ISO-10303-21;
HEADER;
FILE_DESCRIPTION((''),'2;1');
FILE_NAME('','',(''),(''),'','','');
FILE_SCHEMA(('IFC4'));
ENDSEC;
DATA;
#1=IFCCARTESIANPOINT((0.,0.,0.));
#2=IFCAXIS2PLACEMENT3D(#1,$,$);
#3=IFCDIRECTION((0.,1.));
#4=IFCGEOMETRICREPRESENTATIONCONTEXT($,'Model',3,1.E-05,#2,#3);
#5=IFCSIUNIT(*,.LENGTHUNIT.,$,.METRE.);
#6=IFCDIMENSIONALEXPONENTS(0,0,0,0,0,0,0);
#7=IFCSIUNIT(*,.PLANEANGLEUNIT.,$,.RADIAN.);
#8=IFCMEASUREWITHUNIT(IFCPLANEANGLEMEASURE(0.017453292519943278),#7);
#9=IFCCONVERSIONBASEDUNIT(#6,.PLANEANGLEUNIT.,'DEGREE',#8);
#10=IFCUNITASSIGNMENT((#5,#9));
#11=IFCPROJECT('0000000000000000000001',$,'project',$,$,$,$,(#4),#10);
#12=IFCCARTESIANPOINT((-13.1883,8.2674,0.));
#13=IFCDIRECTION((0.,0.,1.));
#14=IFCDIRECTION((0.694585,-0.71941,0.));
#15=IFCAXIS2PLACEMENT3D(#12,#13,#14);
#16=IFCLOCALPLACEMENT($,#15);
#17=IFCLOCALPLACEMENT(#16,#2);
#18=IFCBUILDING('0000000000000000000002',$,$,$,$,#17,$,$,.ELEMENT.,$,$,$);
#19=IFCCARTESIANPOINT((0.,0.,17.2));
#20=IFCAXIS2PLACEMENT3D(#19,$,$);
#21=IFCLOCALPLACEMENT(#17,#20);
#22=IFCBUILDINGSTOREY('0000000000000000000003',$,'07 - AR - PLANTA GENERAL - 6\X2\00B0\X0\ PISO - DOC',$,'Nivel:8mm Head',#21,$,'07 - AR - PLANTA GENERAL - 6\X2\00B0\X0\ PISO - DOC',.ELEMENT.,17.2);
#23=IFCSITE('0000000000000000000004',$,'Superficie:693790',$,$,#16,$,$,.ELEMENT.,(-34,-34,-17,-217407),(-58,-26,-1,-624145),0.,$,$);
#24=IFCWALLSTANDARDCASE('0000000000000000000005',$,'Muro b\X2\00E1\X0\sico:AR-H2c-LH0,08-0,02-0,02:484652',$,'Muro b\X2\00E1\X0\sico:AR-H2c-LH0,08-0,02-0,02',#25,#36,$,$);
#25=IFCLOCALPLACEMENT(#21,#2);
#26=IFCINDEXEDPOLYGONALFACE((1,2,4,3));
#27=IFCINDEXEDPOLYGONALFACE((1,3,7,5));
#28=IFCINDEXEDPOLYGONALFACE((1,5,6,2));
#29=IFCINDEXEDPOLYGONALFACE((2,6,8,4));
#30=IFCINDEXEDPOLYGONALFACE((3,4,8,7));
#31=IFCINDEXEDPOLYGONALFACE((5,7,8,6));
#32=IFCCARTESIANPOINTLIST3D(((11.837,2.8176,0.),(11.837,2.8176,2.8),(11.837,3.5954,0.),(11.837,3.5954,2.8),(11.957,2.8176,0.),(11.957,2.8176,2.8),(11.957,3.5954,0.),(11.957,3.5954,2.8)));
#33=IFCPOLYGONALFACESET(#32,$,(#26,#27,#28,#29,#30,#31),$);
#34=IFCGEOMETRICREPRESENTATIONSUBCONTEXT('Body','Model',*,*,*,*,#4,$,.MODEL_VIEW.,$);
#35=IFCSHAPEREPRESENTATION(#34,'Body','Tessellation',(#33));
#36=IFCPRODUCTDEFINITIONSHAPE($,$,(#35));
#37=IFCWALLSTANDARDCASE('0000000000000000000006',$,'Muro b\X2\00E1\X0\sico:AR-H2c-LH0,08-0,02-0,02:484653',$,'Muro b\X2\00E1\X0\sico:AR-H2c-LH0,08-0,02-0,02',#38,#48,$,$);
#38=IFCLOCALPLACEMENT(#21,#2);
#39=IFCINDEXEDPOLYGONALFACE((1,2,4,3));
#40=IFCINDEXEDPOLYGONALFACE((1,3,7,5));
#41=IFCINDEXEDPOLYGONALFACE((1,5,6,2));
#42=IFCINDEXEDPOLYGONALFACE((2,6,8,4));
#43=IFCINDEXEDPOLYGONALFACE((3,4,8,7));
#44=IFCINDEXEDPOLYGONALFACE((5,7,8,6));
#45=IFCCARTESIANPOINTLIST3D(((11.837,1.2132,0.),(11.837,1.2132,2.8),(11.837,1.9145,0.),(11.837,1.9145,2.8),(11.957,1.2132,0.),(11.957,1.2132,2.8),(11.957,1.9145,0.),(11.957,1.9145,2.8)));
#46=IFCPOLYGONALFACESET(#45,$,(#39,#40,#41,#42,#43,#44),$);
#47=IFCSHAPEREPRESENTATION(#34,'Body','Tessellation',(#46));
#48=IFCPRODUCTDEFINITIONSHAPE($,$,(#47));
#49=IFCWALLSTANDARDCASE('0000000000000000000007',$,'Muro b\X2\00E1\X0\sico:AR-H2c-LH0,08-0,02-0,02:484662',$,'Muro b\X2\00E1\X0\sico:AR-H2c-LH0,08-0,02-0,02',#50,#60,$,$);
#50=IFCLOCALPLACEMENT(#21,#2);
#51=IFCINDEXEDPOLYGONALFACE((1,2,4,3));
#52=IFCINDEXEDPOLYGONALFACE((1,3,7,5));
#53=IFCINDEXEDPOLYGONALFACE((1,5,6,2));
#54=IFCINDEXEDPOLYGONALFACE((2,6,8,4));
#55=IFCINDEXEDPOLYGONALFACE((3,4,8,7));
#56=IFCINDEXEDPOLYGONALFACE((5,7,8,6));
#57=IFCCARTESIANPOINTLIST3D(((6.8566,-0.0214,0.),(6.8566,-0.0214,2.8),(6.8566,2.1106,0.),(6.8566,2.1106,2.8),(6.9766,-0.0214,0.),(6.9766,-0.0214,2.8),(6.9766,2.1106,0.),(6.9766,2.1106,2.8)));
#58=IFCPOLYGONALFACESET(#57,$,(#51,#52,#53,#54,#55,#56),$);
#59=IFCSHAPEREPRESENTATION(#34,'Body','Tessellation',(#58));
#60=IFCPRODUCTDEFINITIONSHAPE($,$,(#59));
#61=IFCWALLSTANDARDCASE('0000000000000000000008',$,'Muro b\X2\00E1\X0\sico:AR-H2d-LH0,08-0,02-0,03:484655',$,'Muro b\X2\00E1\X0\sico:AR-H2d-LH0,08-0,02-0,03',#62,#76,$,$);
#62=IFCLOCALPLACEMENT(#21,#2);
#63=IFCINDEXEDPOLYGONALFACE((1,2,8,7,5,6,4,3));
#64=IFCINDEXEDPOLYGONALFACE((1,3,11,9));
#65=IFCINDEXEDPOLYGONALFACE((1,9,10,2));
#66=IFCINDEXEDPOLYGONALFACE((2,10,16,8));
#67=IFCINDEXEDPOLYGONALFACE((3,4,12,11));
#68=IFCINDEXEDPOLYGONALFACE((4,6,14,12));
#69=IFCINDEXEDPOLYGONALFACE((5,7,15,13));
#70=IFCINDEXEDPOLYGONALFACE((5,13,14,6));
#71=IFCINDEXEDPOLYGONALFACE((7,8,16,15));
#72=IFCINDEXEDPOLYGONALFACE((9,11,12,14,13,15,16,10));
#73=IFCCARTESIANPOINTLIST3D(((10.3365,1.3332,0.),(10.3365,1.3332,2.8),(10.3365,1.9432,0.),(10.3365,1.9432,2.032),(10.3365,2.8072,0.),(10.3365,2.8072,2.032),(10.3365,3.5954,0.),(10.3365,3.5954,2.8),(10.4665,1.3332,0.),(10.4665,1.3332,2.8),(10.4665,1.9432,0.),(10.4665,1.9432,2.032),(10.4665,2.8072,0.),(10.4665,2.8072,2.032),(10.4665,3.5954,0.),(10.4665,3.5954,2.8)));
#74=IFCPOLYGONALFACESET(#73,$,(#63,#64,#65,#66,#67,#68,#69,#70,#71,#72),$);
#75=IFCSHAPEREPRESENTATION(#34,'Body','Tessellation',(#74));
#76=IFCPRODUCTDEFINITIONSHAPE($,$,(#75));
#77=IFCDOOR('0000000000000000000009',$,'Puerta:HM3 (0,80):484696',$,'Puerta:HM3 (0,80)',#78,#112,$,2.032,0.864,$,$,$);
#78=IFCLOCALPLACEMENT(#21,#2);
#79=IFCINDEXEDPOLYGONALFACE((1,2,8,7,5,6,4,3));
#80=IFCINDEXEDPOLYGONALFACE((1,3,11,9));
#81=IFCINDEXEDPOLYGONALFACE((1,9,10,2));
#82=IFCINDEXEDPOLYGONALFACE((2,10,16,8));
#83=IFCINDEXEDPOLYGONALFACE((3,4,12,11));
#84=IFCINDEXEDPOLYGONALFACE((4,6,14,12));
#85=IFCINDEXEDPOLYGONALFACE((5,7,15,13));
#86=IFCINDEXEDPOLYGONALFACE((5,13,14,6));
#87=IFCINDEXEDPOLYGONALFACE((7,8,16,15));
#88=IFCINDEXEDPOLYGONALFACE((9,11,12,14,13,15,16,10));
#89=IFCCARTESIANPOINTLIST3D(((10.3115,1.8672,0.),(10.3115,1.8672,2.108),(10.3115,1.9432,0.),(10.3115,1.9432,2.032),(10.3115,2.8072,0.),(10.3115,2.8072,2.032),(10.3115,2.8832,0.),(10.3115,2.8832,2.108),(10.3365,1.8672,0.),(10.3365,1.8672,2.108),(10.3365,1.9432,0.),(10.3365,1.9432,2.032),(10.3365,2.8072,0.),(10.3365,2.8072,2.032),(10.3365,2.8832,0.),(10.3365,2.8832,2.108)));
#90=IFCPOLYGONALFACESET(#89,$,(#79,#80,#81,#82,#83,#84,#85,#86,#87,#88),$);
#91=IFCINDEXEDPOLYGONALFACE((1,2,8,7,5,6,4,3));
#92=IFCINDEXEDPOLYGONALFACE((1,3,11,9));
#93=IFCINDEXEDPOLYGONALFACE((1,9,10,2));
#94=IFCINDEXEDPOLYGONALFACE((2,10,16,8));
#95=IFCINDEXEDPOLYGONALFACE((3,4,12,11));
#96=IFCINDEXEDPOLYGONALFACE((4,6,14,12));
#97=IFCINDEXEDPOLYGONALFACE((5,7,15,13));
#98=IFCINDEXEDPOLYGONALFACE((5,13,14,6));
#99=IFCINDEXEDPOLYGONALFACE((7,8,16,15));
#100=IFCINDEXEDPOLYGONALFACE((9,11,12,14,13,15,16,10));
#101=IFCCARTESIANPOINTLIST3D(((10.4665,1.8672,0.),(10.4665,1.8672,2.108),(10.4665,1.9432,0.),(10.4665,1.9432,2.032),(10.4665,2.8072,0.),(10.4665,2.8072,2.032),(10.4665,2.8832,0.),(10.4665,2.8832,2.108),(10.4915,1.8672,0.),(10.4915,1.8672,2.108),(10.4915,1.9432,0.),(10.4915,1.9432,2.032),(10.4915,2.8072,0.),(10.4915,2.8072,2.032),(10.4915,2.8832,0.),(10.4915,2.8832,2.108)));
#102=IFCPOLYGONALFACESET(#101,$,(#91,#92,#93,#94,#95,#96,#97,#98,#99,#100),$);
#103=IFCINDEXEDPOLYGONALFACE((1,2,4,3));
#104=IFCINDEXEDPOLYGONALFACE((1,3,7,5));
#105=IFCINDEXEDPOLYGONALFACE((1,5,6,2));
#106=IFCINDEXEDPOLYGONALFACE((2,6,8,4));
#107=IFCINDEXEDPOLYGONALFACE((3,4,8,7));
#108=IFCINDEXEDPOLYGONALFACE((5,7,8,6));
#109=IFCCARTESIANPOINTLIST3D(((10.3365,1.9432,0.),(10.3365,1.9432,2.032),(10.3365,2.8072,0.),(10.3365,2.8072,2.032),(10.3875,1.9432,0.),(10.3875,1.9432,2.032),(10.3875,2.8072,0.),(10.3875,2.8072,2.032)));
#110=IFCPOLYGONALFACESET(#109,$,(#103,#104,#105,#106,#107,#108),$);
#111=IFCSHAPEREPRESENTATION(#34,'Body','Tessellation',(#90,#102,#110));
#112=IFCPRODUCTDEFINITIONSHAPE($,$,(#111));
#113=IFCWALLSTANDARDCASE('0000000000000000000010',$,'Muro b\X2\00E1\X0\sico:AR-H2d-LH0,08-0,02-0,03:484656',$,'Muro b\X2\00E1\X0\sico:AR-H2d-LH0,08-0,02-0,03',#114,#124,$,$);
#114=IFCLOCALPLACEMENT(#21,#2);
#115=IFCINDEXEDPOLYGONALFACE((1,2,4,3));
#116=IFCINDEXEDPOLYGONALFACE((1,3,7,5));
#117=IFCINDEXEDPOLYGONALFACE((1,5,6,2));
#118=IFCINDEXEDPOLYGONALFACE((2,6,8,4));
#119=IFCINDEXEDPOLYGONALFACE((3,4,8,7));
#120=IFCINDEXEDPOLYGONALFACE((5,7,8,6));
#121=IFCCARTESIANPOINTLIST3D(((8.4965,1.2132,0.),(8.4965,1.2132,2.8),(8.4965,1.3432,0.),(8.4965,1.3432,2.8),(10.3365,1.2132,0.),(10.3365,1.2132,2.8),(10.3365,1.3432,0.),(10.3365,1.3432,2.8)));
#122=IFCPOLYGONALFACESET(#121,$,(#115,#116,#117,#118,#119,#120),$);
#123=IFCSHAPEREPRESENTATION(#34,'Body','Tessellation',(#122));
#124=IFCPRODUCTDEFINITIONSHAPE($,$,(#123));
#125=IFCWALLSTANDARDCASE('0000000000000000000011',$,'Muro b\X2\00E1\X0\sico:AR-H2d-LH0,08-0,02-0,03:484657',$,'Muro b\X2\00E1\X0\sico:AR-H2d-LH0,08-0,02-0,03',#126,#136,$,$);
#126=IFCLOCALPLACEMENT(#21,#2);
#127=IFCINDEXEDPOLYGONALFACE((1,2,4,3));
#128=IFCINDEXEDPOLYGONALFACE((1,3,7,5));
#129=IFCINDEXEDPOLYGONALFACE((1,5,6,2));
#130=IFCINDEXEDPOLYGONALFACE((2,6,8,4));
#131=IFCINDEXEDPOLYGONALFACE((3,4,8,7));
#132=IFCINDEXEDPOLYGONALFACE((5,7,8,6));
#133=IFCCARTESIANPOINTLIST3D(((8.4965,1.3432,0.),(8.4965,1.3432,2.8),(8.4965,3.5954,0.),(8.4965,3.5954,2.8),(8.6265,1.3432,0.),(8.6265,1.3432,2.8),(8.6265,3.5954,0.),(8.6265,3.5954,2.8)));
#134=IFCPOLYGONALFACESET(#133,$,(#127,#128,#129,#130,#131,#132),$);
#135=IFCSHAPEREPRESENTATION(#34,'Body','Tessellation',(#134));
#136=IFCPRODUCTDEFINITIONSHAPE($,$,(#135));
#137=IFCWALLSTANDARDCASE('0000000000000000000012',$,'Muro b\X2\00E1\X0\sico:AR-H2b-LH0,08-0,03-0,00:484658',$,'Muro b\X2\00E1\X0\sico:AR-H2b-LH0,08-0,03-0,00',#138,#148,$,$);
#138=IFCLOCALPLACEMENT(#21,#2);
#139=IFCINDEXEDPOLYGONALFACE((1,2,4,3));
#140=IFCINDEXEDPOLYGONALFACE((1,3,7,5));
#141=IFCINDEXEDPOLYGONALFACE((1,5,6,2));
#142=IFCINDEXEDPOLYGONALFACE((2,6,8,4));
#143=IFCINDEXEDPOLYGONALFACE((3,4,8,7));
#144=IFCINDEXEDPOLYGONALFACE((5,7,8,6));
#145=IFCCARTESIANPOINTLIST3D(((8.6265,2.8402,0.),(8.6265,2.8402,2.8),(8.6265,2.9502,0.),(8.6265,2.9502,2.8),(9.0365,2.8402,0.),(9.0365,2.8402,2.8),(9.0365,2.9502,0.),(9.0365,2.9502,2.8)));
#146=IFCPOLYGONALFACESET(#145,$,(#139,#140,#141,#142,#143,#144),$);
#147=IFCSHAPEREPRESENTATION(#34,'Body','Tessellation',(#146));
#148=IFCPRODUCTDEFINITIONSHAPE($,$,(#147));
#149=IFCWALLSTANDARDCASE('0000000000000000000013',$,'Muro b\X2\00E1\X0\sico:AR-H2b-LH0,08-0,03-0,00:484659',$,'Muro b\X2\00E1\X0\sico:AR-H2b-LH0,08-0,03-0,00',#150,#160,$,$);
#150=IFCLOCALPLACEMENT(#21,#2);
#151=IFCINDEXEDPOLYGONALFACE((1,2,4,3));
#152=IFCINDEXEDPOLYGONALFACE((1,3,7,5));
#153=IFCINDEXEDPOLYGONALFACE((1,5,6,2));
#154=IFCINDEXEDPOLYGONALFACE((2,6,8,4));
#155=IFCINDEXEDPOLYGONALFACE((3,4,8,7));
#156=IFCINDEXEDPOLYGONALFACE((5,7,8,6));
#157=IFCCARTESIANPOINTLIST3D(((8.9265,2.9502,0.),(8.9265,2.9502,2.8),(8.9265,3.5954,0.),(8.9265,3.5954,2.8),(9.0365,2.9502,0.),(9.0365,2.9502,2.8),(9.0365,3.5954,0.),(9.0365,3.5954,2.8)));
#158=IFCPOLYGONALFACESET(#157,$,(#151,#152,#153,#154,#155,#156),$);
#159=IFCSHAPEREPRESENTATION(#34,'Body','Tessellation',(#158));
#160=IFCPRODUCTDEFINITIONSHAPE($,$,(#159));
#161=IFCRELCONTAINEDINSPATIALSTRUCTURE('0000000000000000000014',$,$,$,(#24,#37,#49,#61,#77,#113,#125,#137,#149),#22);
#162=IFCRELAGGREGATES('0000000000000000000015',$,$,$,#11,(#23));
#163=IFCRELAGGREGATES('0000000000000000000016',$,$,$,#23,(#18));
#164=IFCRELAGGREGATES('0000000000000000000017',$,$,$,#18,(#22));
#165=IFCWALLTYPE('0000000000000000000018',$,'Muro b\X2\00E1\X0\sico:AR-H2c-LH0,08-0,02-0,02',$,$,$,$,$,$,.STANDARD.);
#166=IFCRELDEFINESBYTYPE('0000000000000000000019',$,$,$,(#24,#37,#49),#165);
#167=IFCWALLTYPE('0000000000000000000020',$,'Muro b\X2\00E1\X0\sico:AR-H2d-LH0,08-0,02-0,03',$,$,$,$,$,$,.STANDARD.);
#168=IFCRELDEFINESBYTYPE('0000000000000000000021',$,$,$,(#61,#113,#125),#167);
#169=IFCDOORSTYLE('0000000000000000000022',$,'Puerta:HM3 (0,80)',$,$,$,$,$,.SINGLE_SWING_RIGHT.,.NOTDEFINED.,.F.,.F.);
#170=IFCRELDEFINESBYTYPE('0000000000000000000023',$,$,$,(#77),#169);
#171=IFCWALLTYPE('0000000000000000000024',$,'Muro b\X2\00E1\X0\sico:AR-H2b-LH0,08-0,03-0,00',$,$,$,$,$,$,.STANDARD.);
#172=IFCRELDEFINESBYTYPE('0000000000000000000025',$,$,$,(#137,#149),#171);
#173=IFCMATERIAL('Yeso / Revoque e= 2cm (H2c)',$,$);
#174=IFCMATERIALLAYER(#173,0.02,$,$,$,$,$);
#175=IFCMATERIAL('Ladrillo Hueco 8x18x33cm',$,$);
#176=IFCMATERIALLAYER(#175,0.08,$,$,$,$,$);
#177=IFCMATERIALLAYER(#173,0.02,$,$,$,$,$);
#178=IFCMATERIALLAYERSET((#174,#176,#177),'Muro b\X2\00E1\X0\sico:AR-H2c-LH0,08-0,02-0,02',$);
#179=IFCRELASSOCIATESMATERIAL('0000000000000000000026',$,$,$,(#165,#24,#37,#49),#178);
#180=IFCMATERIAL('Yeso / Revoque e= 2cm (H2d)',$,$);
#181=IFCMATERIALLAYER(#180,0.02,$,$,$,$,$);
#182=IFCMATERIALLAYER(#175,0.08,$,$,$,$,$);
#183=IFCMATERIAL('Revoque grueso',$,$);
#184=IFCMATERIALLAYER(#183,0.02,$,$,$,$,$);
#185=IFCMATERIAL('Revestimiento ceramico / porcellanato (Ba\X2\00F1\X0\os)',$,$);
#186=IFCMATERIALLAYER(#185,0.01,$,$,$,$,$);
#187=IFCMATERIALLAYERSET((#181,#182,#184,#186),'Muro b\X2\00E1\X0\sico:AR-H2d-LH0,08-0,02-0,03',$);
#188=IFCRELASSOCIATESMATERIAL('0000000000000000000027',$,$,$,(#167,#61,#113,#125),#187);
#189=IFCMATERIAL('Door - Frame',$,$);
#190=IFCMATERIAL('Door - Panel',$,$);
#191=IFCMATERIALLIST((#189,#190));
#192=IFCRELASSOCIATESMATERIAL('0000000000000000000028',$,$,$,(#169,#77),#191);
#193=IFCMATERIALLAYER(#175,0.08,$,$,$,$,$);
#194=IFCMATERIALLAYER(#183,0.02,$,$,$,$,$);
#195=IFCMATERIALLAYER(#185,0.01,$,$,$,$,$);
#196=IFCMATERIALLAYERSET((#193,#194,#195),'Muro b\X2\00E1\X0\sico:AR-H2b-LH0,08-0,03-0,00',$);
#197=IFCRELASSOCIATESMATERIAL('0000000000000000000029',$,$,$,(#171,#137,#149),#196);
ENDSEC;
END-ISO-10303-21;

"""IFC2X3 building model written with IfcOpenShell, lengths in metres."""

from ifc_helpers import new_model, entity, si_unit, converted_unit, direction, frame, frame_2d, origin, place, context, subcontext, project, spatial, polyline, rectangle, outline, extrude, source, transform, mapped, material, material_list, layer, layer_set, layer_usage, type_object, type_shapes, element, fill, save


model = new_model("IFC2X3")

# Units and contexts
model_context = context("Model", 3, precision=1e-05, world=origin(), true_north=direction((0.0, 1.0)))
body_context = subcontext(model_context, "Body", "Model", "MODEL_VIEW")
ifc_project = project(units=[si_unit("LENGTHUNIT", "METRE"), converted_unit("PLANEANGLEUNIT", "DEGREE", entity("IfcPlaneAngleMeasure", 0.017453292519943278), si_unit("PLANEANGLEUNIT", "RADIAN"), dimensions=[0, 0, 0, 0, 0, 0, 0])], contexts=[model_context])

# Site, building, storey
site_placement = place(None, frame((-13.1883, 8.2674, 0.0), z_axis=(0.0, 0.0, 1.0), x_axis=(0.694585, -0.71941, 0.0)))
site = spatial("IfcSite", under=ifc_project, at=site_placement, Name="Superficie:693790", CompositionType="ELEMENT", RefLatitude=(-34, -34, -17, -217407), RefLongitude=(-58, -26, -1, -624145), RefElevation=0.0)
building_placement = place(site_placement, origin())
building = spatial("IfcBuilding", under=site, at=building_placement, CompositionType="ELEMENT")
storey_placement = place(building_placement, frame((0.0, 0.0, 17.2)))
storey = spatial("IfcBuildingStorey", under=building, at=storey_placement, Name="07 - AR - PLANTA GENERAL - 6° PISO - DOC", ObjectType="Nivel:8mm Head", LongName="07 - AR - PLANTA GENERAL - 6° PISO - DOC", CompositionType="ELEMENT", Elevation=17.2)

# Walls
ifc_material_1 = material(Name="Yeso / Revoque e= 2cm (H2c)")
ifc_layer_1 = layer(ifc_material_1, 0.02)
ifc_material_2 = material(Name="Ladrillo Hueco 8x18x33cm")
ifc_layer_2 = layer(ifc_material_2, 0.08)
ifc_layer_3 = layer(ifc_material_1, 0.02)
ifc_layer_set_1 = layer_set([ifc_layer_1, ifc_layer_2, ifc_layer_3], Name="Muro básico:AR-H2c-LH0,08-0,02-0,02")
ifc_layer_usage_1 = layer_usage(ifc_layer_set_1, "AXIS2", "NEGATIVE", 0.06)
wall_type_1 = type_object("IfcWallType", Name="Muro básico:AR-H2c-LH0,08-0,02-0,02", PredefinedType="STANDARD", material=ifc_layer_set_1)
wall_1_placement = place(storey_placement, frame((11.897, 3.5954, 0.0), z_axis=(0.0, 0.0, 1.0), x_axis=(0.0, -1.0, 0.0)))
element("IfcWallStandardCase", 1, at=wall_1_placement, inside=storey, type_object=wall_type_1, material=ifc_layer_usage_1, Name="Muro básico:AR-H2c-LH0,08-0,02-0,02:484652", ObjectType="Muro básico:AR-H2c-LH0,08-0,02-0,02", context=body_context, shape_type="SweptSolid", body=[
    extrude(rectangle(XDim=0.7779, YDim=0.12, at=frame_2d((0.3889, 0.0), x_axis=(-1.0, 0.0))), origin(), (0.0, 0.0, 1.0), 2.8),
])
ifc_layer_usage_2 = layer_usage(ifc_layer_set_1, "AXIS2", "NEGATIVE", 0.06)
wall_2_placement = place(storey_placement, frame((11.897, 1.9145, 0.0), z_axis=(0.0, 0.0, 1.0), x_axis=(0.0, -1.0, 0.0)))
element("IfcWallStandardCase", 2, at=wall_2_placement, inside=storey, type_object=wall_type_1, material=ifc_layer_usage_2, Name="Muro básico:AR-H2c-LH0,08-0,02-0,02:484653", ObjectType="Muro básico:AR-H2c-LH0,08-0,02-0,02", context=body_context, shape_type="SweptSolid", body=[
    extrude(rectangle(XDim=0.7014, YDim=0.12, at=frame_2d((0.3507, 0.0), x_axis=(-1.0, 0.0))), origin(), (0.0, 0.0, 1.0), 2.8),
])
ifc_layer_usage_3 = layer_usage(ifc_layer_set_1, "AXIS2", "NEGATIVE", 0.06)
wall_3_placement = place(storey_placement, frame((6.9166, 2.1106, 0.0), z_axis=(0.0, 0.0, 1.0), x_axis=(0.0, -1.0, 0.0)))
element("IfcWallStandardCase", 3, at=wall_3_placement, inside=storey, type_object=wall_type_1, material=ifc_layer_usage_3, Name="Muro básico:AR-H2c-LH0,08-0,02-0,02:484662", ObjectType="Muro básico:AR-H2c-LH0,08-0,02-0,02", context=body_context, shape_type="SweptSolid", body=[
    extrude(rectangle(XDim=2.132, YDim=0.12, at=frame_2d((1.066, 0.0), x_axis=(-1.0, 0.0))), origin(), (0.0, 0.0, 1.0), 2.8),
])

# Wall, opening, door
ifc_material_3 = material(Name="Yeso / Revoque e= 2cm (H2d)")
ifc_layer_4 = layer(ifc_material_3, 0.02)
ifc_layer_5 = layer(ifc_material_2, 0.08)
ifc_material_4 = material(Name="Revoque grueso")
ifc_layer_6 = layer(ifc_material_4, 0.02)
ifc_material_5 = material(Name="Revestimiento ceramico / porcellanato (Baños)")
ifc_layer_7 = layer(ifc_material_5, 0.01)
ifc_layer_set_2 = layer_set([ifc_layer_4, ifc_layer_5, ifc_layer_6, ifc_layer_7], Name="Muro básico:AR-H2d-LH0,08-0,02-0,03")
ifc_layer_usage_4 = layer_usage(ifc_layer_set_2, "AXIS2", "POSITIVE", -0.065)
wall_type_2 = type_object("IfcWallType", Name="Muro básico:AR-H2d-LH0,08-0,02-0,03", PredefinedType="STANDARD", material=ifc_layer_set_2)
wall_4_placement = place(storey_placement, frame((10.4015, 1.3332, 0.0), z_axis=(0.0, 0.0, 1.0), x_axis=(0.0, 1.0, 0.0)))
wall_4 = element("IfcWallStandardCase", 4, at=wall_4_placement, inside=storey, type_object=wall_type_2, material=ifc_layer_usage_4, Name="Muro básico:AR-H2d-LH0,08-0,02-0,03:484655", ObjectType="Muro básico:AR-H2d-LH0,08-0,02-0,03", context=body_context, shape_type="SweptSolid", body=[
    extrude(rectangle(XDim=2.2623, YDim=0.13, at=frame_2d((1.1311, 0.0), x_axis=(-1.0, 0.0))), origin(), (0.0, 0.0, 1.0), 2.8),
])
opening_1_placement = place(wall_4_placement, frame((0.61, -0.065, 0.0)))
opening_1 = element("IfcOpeningElement", 5, at=opening_1_placement, cuts=wall_4, ObjectType="Opening", context=body_context, shape_type="SweptSolid", body=[
    extrude(rectangle(XDim=0.864, YDim=2.032, at=frame_2d((1.016, 0.432), x_axis=(0.0, 1.0))), frame((0.0, 0.0, 0.0), z_axis=(0.0, 1.0, 0.0), x_axis=(0.0, 0.0, 1.0)), (0.0, 0.0, 1.0), 0.13),
])
ifc_material_6 = material(Name="Door - Frame")
ifc_material_7 = material(Name="Door - Panel")
ifc_material_list = material_list([ifc_material_6, ifc_material_7])
door_style_1 = type_object("IfcDoorStyle", Name="Puerta:HM3 (0,80)", ConstructionType="NOTDEFINED", OperationType="SINGLE_SWING_RIGHT", ParameterTakesPrecedence=False, Sizeable=False, material=ifc_material_list)
shared_shape_1 = source(origin(), body_context, "Body", "SweptSolid", [
    extrude(outline(polyline([(-0.508, -1.073), (0.508, -1.073), (0.508, 1.035), (0.432, 1.035), (0.432, -0.997), (-0.432, -0.997), (-0.432, 1.035), (-0.508, 1.035), (-0.508, -1.073)])), frame((0.432, 0.13, 1.035), z_axis=(0.0, 1.0, 0.0), x_axis=(1.0, 0.0, 0.0)), (0.0, 0.0, 1.0), 0.025),
    extrude(outline(polyline([(-1.073, -0.508), (1.035, -0.508), (1.035, -0.432), (-0.997, -0.432), (-0.997, 0.432), (1.035, 0.432), (1.035, 0.508), (-1.073, 0.508), (-1.073, -0.508)])), frame((0.432, -0.025, 1.035), z_axis=(0.0, 1.0, 0.0), x_axis=(0.0, 0.0, -1.0)), (0.0, 0.0, 1.0), 0.025),
    extrude(rectangle(XDim=0.051, YDim=0.864, at=frame_2d((0.0, 0.0), x_axis=(1.0, 0.0))), frame((0.432, 0.1045, 0.0), z_axis=(0.0, 0.0, 1.0), x_axis=(0.0, 1.0, 0.0)), (0.0, 0.0, 1.0), 2.032),
])
type_shapes(door_style_1, [shared_shape_1])
door_1_placement = place(opening_1_placement, origin())
door_1 = element("IfcDoor", 6, at=door_1_placement, inside=storey, type_object=door_style_1, material=ifc_material_list, Name="Puerta:HM3 (0,80):484696", ObjectType="Puerta:HM3 (0,80)", OverallHeight=2.032, OverallWidth=0.864, context=body_context, shape_type="MappedRepresentation", body=[
    mapped(shared_shape_1, transform((0.0, 0.0, 0.0), scale=1.0)),
])
fill(opening_1, door_1)

# Walls
ifc_layer_usage_5 = layer_usage(ifc_layer_set_2, "AXIS2", "NEGATIVE", 0.065)
wall_5_placement = place(storey_placement, frame((10.3365, 1.2782, 0.0), z_axis=(0.0, 0.0, 1.0), x_axis=(-1.0, 0.0, 0.0)))
element("IfcWallStandardCase", 7, at=wall_5_placement, inside=storey, type_object=wall_type_2, material=ifc_layer_usage_5, Name="Muro básico:AR-H2d-LH0,08-0,02-0,03:484656", ObjectType="Muro básico:AR-H2d-LH0,08-0,02-0,03", context=body_context, shape_type="SweptSolid", body=[
    extrude(rectangle(XDim=1.84, YDim=0.13, at=frame_2d((0.92, 0.0), x_axis=(-1.0, 0.0))), origin(), (0.0, 0.0, 1.0), 2.8),
])
ifc_layer_usage_6 = layer_usage(ifc_layer_set_2, "AXIS2", "NEGATIVE", 0.065)
wall_6_placement = place(storey_placement, frame((8.5615, 1.3432, 0.0), z_axis=(0.0, 0.0, 1.0), x_axis=(0.0, 1.0, 0.0)))
element("IfcWallStandardCase", 8, at=wall_6_placement, inside=storey, type_object=wall_type_2, material=ifc_layer_usage_6, Name="Muro básico:AR-H2d-LH0,08-0,02-0,03:484657", ObjectType="Muro básico:AR-H2d-LH0,08-0,02-0,03", context=body_context, shape_type="SweptSolid", body=[
    extrude(rectangle(XDim=2.2523, YDim=0.13, at=frame_2d((1.1261, 0.0), x_axis=(-1.0, 0.0))), origin(), (0.0, 0.0, 1.0), 2.8),
])
ifc_layer_8 = layer(ifc_material_2, 0.08)
ifc_layer_9 = layer(ifc_material_4, 0.02)
ifc_layer_10 = layer(ifc_material_5, 0.01)
ifc_layer_set_3 = layer_set([ifc_layer_8, ifc_layer_9, ifc_layer_10], Name="Muro básico:AR-H2b-LH0,08-0,03-0,00")
ifc_layer_usage_7 = layer_usage(ifc_layer_set_3, "AXIS2", "NEGATIVE", 0.055)
wall_type_3 = type_object("IfcWallType", Name="Muro básico:AR-H2b-LH0,08-0,03-0,00", PredefinedType="STANDARD", material=ifc_layer_set_3)
wall_7_placement = place(storey_placement, frame((8.6265, 2.8952, 0.0)))
element("IfcWallStandardCase", 9, at=wall_7_placement, inside=storey, type_object=wall_type_3, material=ifc_layer_usage_7, Name="Muro básico:AR-H2b-LH0,08-0,03-0,00:484658", ObjectType="Muro básico:AR-H2b-LH0,08-0,03-0,00", context=body_context, shape_type="SweptSolid", body=[
    extrude(rectangle(XDim=0.41, YDim=0.11, at=frame_2d((0.205, 0.0), x_axis=(-1.0, 0.0))), origin(), (0.0, 0.0, 1.0), 2.8),
])
ifc_layer_usage_8 = layer_usage(ifc_layer_set_3, "AXIS2", "NEGATIVE", 0.055)
wall_8_placement = place(storey_placement, frame((8.9815, 2.9502, 0.0), z_axis=(0.0, 0.0, 1.0), x_axis=(0.0, 1.0, 0.0)))
element("IfcWallStandardCase", 10, at=wall_8_placement, inside=storey, type_object=wall_type_3, material=ifc_layer_usage_8, Name="Muro básico:AR-H2b-LH0,08-0,03-0,00:484659", ObjectType="Muro básico:AR-H2b-LH0,08-0,03-0,00", context=body_context, shape_type="SweptSolid", body=[
    extrude(rectangle(XDim=0.6453, YDim=0.11, at=frame_2d((0.3226, 0.0), x_axis=(-1.0, 0.0))), origin(), (0.0, 0.0, 1.0), 2.8),
])

save(model, "model.ifc")
